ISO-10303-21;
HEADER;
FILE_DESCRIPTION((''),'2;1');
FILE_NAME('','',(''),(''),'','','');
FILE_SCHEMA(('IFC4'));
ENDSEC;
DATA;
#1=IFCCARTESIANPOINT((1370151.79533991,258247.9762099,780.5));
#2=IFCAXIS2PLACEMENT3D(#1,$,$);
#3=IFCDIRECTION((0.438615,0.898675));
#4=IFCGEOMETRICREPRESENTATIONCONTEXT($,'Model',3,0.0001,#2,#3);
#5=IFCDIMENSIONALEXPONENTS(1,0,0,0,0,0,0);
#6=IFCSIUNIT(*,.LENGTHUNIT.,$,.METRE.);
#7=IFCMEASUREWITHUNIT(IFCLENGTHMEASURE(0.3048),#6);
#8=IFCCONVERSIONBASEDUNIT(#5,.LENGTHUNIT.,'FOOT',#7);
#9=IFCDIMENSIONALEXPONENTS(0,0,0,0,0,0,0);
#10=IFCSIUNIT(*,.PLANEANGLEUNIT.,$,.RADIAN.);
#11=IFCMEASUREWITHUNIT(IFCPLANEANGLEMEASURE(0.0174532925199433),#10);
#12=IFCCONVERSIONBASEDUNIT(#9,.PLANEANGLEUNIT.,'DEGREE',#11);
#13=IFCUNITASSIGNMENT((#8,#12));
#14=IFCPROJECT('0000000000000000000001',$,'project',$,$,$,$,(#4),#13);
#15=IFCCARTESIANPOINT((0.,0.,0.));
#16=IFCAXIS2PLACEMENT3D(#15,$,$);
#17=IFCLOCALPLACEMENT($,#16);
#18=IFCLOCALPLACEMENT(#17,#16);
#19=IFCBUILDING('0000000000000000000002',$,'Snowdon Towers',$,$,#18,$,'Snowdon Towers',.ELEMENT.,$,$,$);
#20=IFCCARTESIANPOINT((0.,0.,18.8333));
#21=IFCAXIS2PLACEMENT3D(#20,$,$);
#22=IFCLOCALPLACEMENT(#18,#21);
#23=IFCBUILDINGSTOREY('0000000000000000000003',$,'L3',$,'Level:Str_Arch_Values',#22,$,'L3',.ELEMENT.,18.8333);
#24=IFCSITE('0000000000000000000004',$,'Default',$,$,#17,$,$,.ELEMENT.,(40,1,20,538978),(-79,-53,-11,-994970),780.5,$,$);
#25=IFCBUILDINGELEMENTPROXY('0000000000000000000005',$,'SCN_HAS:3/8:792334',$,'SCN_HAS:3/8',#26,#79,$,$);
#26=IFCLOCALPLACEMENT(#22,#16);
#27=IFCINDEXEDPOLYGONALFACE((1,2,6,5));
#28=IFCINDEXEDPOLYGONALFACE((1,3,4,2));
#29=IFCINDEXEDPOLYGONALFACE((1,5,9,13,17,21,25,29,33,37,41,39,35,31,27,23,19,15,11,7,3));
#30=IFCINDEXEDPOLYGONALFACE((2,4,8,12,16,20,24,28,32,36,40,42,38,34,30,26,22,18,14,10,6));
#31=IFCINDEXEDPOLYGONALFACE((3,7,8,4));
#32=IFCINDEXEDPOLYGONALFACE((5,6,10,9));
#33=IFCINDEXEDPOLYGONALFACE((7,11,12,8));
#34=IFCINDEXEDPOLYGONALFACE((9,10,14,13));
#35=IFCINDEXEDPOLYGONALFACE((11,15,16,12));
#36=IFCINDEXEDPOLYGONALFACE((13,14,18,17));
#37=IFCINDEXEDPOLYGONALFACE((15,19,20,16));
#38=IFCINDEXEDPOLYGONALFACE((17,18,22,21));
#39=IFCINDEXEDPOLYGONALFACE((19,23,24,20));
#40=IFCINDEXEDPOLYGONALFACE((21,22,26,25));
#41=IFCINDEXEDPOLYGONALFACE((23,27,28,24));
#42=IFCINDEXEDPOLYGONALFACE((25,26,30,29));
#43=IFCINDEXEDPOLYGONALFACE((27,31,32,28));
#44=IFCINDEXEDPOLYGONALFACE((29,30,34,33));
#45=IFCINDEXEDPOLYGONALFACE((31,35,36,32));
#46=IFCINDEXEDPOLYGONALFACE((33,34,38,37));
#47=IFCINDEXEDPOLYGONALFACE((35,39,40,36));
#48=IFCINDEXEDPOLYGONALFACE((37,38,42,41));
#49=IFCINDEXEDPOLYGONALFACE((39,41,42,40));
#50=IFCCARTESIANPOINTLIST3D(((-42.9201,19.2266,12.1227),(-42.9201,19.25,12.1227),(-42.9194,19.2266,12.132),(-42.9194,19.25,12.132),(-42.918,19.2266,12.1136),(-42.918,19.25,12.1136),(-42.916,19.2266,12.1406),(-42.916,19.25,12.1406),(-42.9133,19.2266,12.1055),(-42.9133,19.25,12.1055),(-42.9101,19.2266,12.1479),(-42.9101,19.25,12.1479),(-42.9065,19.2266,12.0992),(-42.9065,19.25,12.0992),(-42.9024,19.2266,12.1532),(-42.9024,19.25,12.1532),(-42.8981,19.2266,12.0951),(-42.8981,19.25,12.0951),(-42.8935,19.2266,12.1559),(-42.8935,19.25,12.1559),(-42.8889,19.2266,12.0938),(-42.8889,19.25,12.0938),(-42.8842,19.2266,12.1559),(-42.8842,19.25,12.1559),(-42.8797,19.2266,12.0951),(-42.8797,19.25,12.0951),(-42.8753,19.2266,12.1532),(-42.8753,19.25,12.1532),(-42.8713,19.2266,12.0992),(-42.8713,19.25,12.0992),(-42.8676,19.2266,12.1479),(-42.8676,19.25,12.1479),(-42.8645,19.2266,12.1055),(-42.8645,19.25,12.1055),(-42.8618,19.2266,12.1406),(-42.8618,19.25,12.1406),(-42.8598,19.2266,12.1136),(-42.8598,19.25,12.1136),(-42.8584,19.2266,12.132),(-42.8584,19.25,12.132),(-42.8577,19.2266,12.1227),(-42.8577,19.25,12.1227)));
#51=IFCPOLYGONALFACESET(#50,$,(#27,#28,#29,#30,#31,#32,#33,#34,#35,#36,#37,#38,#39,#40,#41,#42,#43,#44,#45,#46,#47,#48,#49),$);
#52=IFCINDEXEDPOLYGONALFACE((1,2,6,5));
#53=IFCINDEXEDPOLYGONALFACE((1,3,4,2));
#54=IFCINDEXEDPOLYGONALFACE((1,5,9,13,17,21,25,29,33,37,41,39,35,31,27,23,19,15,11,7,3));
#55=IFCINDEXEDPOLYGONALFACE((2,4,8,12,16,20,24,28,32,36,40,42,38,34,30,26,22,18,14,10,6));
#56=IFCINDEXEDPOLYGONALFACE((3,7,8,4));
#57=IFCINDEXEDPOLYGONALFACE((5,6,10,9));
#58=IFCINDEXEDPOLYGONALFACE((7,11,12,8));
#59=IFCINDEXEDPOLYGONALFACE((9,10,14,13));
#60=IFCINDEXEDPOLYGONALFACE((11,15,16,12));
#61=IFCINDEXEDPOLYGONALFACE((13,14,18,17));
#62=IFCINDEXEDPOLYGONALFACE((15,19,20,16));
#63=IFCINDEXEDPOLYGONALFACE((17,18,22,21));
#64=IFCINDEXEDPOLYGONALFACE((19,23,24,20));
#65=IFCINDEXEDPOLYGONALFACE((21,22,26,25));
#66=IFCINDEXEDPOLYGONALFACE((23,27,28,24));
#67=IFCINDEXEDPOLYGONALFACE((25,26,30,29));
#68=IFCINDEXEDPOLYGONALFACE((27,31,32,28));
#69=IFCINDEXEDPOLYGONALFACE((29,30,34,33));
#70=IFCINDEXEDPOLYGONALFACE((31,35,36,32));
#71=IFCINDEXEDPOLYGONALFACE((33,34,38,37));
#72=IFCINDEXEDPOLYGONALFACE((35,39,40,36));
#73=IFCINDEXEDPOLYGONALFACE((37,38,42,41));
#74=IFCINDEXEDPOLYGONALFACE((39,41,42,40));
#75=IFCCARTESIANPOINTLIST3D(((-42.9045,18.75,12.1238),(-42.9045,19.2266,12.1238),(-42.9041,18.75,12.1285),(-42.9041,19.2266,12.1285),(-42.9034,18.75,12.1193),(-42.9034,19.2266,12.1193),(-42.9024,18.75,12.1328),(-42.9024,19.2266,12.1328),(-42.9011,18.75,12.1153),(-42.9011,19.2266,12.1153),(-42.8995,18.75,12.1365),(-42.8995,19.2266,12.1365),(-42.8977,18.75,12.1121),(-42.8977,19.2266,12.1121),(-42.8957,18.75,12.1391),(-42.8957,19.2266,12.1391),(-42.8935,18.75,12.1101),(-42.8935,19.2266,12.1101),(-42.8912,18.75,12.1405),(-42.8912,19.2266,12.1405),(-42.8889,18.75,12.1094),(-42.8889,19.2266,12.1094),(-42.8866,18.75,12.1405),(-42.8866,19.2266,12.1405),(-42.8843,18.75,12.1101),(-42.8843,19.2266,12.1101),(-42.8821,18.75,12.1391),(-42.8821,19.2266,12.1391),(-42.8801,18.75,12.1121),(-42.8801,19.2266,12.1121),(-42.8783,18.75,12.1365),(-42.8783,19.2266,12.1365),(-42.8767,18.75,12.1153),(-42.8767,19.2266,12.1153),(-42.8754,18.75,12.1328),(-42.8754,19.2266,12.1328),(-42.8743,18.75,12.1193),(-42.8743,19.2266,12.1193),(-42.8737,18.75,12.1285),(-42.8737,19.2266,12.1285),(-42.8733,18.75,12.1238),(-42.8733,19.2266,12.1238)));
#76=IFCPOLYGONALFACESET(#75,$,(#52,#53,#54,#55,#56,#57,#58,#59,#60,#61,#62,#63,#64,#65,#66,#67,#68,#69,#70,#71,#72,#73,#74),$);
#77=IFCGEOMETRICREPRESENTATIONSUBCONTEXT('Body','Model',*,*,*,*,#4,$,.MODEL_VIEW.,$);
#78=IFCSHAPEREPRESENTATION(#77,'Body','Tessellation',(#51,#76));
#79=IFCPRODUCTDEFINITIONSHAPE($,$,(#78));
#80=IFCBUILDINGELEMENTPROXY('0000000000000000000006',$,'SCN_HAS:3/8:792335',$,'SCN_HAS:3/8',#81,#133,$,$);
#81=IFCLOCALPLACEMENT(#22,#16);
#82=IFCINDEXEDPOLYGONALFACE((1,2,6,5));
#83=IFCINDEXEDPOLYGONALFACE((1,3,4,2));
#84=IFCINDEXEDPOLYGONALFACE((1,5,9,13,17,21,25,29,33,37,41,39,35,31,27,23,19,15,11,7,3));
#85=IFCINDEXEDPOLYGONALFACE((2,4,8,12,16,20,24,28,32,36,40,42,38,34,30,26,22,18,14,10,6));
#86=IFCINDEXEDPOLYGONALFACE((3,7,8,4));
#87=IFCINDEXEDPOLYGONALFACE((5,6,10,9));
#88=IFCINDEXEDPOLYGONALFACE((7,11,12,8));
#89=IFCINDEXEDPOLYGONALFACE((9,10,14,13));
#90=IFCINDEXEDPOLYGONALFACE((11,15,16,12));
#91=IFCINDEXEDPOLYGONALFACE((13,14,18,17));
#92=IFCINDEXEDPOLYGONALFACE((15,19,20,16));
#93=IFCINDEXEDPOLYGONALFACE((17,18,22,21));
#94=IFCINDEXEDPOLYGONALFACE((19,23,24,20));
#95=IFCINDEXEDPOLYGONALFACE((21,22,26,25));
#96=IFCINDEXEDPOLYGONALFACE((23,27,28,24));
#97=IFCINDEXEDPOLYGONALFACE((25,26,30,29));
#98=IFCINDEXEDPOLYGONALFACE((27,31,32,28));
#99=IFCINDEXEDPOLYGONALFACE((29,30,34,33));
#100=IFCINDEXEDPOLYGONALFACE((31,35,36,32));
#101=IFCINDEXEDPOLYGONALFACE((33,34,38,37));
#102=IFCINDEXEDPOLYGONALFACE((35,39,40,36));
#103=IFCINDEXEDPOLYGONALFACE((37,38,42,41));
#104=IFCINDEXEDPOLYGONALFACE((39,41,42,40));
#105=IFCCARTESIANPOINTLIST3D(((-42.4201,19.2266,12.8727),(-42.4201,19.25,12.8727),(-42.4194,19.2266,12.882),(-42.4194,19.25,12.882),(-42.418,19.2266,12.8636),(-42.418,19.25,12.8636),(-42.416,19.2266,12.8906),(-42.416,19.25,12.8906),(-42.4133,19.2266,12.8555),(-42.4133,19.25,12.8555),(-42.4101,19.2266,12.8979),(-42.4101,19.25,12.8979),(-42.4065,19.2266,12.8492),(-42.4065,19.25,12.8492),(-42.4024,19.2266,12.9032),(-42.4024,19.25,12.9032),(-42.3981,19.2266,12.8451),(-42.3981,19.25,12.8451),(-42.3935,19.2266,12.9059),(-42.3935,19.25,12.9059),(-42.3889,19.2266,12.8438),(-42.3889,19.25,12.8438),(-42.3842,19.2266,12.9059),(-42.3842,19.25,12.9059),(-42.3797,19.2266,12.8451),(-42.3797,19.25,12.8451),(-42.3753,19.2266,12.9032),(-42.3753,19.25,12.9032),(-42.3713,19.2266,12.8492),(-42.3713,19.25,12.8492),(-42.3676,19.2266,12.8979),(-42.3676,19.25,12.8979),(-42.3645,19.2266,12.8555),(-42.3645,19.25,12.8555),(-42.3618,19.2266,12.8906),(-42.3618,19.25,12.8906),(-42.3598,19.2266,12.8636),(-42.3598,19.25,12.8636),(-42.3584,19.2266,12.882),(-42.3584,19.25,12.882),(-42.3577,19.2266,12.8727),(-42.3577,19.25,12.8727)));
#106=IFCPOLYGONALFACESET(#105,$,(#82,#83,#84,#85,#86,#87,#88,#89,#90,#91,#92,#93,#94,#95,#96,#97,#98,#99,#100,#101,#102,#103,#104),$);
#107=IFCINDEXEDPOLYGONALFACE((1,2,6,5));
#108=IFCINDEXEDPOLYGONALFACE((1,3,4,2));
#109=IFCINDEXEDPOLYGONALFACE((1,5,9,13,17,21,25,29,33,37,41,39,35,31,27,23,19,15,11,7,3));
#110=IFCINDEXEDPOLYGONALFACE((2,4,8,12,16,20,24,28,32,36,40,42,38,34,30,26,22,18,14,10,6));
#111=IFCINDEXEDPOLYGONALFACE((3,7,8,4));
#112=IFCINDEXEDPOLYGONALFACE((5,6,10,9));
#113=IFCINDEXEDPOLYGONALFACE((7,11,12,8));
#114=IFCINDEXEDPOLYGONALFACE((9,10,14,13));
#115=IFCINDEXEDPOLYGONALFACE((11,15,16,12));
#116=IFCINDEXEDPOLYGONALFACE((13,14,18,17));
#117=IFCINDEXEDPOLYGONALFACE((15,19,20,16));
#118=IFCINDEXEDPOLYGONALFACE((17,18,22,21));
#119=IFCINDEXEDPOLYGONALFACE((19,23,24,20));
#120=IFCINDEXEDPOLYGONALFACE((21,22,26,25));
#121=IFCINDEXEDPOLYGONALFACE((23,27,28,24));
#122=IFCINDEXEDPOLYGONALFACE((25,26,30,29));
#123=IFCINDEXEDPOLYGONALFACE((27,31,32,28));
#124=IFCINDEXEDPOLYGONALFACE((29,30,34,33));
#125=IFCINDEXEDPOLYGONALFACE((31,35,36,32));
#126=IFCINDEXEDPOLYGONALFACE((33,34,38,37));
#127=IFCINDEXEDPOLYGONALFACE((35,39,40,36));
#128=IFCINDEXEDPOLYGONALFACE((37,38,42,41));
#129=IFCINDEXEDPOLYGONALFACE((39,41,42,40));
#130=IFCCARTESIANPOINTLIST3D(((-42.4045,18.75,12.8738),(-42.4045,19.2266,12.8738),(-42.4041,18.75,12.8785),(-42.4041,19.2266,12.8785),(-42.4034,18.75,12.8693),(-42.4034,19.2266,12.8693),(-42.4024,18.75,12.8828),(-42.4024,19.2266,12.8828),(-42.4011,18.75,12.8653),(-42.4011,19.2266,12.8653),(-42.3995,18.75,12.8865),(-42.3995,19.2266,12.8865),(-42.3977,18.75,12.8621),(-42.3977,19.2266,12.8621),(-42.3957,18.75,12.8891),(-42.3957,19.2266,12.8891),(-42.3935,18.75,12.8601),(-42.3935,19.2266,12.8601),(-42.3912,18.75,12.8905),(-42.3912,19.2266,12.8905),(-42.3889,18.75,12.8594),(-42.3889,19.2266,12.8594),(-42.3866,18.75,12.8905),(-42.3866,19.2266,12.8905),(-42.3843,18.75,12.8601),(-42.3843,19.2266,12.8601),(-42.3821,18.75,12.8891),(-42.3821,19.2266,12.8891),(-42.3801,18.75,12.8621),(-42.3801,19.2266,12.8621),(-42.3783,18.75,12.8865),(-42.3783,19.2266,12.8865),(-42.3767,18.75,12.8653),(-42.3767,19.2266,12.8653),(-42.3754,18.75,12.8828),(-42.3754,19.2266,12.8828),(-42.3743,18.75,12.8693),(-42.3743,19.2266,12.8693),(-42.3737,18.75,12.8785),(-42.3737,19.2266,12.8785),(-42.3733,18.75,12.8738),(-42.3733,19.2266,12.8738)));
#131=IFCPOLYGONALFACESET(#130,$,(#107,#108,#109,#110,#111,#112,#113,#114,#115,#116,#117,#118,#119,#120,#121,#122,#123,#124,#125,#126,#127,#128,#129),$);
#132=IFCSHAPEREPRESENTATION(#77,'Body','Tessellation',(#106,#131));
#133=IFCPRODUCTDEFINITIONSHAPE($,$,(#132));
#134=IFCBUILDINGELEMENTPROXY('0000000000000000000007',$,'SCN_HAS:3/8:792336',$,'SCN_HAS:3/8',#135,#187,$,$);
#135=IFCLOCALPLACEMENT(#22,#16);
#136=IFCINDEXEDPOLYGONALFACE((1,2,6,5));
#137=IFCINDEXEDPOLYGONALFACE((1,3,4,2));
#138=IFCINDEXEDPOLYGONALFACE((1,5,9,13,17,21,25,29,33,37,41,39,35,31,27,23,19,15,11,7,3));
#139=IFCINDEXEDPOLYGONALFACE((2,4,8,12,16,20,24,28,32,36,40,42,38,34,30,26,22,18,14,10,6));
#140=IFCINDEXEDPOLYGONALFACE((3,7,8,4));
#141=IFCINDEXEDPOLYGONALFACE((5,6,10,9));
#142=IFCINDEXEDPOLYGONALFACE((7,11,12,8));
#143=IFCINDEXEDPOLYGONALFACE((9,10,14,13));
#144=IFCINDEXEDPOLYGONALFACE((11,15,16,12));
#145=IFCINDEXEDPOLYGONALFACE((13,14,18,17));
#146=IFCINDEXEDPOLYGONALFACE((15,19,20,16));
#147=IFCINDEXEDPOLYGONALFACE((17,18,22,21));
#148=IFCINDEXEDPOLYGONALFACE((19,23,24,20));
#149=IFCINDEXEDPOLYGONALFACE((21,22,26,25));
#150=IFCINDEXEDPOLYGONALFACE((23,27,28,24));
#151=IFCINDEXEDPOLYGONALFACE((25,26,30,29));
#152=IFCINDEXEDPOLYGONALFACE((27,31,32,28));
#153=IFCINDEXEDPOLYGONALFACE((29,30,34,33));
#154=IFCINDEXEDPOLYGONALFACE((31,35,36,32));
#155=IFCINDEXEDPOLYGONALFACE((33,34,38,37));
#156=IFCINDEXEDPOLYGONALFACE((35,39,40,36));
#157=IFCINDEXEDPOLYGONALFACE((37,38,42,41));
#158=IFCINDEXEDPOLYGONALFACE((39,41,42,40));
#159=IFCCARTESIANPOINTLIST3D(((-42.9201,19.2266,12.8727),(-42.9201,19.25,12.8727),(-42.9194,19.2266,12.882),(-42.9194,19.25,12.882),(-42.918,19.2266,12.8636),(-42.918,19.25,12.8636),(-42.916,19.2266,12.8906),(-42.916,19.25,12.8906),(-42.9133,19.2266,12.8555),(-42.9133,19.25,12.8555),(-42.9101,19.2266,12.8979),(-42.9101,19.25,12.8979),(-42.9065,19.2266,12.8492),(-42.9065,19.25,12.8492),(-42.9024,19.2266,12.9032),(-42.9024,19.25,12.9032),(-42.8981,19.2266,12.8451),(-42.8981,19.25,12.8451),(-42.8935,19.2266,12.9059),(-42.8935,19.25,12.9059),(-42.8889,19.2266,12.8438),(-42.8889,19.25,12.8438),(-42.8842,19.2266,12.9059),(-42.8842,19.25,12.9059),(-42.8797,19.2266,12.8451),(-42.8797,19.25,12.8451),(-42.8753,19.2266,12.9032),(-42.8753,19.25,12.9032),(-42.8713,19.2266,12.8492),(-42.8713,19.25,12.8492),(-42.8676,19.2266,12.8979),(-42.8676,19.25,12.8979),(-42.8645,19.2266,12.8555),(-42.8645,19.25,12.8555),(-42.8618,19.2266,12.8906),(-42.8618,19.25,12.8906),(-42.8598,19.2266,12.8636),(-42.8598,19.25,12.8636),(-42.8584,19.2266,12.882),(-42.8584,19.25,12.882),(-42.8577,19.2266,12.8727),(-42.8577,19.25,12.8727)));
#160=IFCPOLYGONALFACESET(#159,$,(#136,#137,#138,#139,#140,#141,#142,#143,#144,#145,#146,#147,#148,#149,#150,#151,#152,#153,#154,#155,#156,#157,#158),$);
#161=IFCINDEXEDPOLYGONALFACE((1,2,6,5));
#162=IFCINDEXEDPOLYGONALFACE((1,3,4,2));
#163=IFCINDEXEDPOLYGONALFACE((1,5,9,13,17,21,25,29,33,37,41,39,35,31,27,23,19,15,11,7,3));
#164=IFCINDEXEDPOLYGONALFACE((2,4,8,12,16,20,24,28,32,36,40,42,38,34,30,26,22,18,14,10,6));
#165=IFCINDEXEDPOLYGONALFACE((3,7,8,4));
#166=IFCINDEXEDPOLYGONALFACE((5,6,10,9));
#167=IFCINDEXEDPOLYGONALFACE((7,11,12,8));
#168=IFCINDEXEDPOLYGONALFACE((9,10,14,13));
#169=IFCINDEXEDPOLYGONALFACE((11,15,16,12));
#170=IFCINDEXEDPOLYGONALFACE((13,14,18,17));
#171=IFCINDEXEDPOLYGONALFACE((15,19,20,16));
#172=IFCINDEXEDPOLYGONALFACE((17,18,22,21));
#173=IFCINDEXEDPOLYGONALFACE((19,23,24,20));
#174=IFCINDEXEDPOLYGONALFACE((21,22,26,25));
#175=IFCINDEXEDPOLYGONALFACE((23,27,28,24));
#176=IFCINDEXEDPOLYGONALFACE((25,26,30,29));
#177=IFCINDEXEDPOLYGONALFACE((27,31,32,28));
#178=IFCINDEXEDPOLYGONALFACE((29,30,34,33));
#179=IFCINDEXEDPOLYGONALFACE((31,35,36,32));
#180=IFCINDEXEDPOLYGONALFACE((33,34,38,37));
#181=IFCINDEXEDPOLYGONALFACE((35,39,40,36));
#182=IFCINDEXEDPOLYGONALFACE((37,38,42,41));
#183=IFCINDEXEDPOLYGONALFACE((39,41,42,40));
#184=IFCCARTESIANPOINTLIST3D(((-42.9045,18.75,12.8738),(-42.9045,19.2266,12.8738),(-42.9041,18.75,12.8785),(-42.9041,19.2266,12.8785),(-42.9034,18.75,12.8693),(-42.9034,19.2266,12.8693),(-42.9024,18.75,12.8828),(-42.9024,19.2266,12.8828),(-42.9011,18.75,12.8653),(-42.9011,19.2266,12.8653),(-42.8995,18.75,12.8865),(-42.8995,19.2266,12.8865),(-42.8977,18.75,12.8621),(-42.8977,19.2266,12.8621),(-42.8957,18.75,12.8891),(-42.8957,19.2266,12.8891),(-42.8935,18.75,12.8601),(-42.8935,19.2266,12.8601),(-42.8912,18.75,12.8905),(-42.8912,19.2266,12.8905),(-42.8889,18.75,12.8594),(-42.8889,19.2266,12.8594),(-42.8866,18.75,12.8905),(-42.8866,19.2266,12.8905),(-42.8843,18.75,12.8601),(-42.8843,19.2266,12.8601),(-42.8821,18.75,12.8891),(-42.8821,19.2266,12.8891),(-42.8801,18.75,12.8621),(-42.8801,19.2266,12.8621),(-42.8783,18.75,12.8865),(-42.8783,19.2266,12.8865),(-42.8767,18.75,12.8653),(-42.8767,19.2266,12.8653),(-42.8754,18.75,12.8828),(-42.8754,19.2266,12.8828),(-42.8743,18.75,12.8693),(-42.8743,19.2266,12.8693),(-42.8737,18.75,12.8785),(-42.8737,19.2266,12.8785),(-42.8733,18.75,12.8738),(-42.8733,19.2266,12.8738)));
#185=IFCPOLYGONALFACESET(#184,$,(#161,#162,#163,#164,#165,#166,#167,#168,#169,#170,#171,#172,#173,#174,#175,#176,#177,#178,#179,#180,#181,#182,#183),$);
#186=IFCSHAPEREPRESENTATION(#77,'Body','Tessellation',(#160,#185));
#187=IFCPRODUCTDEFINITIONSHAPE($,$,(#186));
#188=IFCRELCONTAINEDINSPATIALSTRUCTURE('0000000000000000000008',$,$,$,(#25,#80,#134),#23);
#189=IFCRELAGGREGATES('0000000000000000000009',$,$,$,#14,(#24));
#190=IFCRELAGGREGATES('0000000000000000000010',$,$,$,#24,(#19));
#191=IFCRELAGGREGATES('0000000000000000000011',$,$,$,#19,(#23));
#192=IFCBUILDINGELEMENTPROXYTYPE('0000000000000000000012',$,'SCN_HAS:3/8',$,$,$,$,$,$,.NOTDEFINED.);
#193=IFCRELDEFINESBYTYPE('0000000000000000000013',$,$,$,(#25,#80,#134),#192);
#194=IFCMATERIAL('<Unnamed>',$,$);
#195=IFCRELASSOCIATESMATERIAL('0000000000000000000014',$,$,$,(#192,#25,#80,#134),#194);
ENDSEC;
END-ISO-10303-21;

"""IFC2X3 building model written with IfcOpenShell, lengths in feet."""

from ifc_helpers import new_model, entity, si_unit, converted_unit, direction, frame, frame_2d, origin, place, context, subcontext, project, spatial, circle, extrude, source, transform, mapped, material, type_object, type_shapes, element, save


model = new_model("IFC2X3")

# Units and contexts
model_context = context("Model", 3, precision=0.0001, world=frame((1370151.79533991, 258247.9762099, 780.5)), true_north=direction((0.438615, 0.898675)))
body_context = subcontext(model_context, "Body", "Model", "MODEL_VIEW")
ifc_project = project(units=[converted_unit("LENGTHUNIT", "FOOT", entity("IfcLengthMeasure", 0.3048), si_unit("LENGTHUNIT", "METRE"), dimensions=[1, 0, 0, 0, 0, 0, 0]), converted_unit("PLANEANGLEUNIT", "DEGREE", entity("IfcPlaneAngleMeasure", 0.0174532925199433), si_unit("PLANEANGLEUNIT", "RADIAN"), dimensions=[0, 0, 0, 0, 0, 0, 0])], contexts=[model_context])

# Site, building, storey
site_placement = place(None, origin())
site = spatial("IfcSite", under=ifc_project, at=site_placement, Name="Default", CompositionType="ELEMENT", RefLatitude=(40, 1, 20, 538978), RefLongitude=(-79, -53, -11, -994970), RefElevation=780.5)
building_placement = place(site_placement, origin())
building = spatial("IfcBuilding", under=site, at=building_placement, Name="Snowdon Towers", LongName="Snowdon Towers", CompositionType="ELEMENT")
storey_placement = place(building_placement, frame((0.0, 0.0, 18.8333)))
storey = spatial("IfcBuildingStorey", under=building, at=storey_placement, Name="L3", ObjectType="Level:Str_Arch_Values", LongName="L3", CompositionType="ELEMENT", Elevation=18.8333)

# Building element proxies
ifc_material_1 = material(Name="<Unnamed>")
building_element_proxy_type_1 = type_object("IfcBuildingElementProxyType", Name="SCN_HAS:3/8", PredefinedType="NOTDEFINED", material=ifc_material_1)
shared_shape_1 = source(origin(), body_context, "Body", "SweptSolid", [
    extrude(circle(Radius=0.0312, at=frame_2d((0.0, 0.0), x_axis=(1.0, 0.0))), frame((0.0, 0.0, -0.5), z_axis=(0.0, 0.0, 1.0), x_axis=(0.0, -1.0, 0.0)), (0.0, 0.0, 1.0), 0.0234),
    extrude(circle(Radius=0.0156, at=frame_2d((0.0, 0.0), x_axis=(1.0, 0.0))), frame((0.0, 0.0, -0.4766), z_axis=(0.0, 0.0, 1.0), x_axis=(0.0, -1.0, 0.0)), (0.0, 0.0, 1.0), 0.4766),
])
type_shapes(building_element_proxy_type_1, [shared_shape_1])
for number, where, z_axis, x_axis, name in (
    (1, (-42.8889, 18.75, 12.125), (0.0, -1.0, 0.0), (1.0, 0.0, 0.0), "SCN_HAS:3/8:792334"),
    (2, (-42.3889, 18.75, 12.875), (0.0, -1.0, 0.0), (1.0, 0.0, 0.0), "SCN_HAS:3/8:792335"),
    (3, (-42.8889, 18.75, 12.875), (0.0, -1.0, 0.0), (1.0, 0.0, 0.0), "SCN_HAS:3/8:792336"),
):
    element("IfcBuildingElementProxy", number, at=place(storey_placement, frame(where, z_axis=z_axis, x_axis=x_axis)), inside=storey, type_object=building_element_proxy_type_1, material=ifc_material_1, Name=name, ObjectType="SCN_HAS:3/8", context=body_context, shape_type="MappedRepresentation", body=[
        mapped(shared_shape_1, transform((0.0, 0.0, 0.0), scale=1.0)),
    ])

save(model, "model.ifc")
